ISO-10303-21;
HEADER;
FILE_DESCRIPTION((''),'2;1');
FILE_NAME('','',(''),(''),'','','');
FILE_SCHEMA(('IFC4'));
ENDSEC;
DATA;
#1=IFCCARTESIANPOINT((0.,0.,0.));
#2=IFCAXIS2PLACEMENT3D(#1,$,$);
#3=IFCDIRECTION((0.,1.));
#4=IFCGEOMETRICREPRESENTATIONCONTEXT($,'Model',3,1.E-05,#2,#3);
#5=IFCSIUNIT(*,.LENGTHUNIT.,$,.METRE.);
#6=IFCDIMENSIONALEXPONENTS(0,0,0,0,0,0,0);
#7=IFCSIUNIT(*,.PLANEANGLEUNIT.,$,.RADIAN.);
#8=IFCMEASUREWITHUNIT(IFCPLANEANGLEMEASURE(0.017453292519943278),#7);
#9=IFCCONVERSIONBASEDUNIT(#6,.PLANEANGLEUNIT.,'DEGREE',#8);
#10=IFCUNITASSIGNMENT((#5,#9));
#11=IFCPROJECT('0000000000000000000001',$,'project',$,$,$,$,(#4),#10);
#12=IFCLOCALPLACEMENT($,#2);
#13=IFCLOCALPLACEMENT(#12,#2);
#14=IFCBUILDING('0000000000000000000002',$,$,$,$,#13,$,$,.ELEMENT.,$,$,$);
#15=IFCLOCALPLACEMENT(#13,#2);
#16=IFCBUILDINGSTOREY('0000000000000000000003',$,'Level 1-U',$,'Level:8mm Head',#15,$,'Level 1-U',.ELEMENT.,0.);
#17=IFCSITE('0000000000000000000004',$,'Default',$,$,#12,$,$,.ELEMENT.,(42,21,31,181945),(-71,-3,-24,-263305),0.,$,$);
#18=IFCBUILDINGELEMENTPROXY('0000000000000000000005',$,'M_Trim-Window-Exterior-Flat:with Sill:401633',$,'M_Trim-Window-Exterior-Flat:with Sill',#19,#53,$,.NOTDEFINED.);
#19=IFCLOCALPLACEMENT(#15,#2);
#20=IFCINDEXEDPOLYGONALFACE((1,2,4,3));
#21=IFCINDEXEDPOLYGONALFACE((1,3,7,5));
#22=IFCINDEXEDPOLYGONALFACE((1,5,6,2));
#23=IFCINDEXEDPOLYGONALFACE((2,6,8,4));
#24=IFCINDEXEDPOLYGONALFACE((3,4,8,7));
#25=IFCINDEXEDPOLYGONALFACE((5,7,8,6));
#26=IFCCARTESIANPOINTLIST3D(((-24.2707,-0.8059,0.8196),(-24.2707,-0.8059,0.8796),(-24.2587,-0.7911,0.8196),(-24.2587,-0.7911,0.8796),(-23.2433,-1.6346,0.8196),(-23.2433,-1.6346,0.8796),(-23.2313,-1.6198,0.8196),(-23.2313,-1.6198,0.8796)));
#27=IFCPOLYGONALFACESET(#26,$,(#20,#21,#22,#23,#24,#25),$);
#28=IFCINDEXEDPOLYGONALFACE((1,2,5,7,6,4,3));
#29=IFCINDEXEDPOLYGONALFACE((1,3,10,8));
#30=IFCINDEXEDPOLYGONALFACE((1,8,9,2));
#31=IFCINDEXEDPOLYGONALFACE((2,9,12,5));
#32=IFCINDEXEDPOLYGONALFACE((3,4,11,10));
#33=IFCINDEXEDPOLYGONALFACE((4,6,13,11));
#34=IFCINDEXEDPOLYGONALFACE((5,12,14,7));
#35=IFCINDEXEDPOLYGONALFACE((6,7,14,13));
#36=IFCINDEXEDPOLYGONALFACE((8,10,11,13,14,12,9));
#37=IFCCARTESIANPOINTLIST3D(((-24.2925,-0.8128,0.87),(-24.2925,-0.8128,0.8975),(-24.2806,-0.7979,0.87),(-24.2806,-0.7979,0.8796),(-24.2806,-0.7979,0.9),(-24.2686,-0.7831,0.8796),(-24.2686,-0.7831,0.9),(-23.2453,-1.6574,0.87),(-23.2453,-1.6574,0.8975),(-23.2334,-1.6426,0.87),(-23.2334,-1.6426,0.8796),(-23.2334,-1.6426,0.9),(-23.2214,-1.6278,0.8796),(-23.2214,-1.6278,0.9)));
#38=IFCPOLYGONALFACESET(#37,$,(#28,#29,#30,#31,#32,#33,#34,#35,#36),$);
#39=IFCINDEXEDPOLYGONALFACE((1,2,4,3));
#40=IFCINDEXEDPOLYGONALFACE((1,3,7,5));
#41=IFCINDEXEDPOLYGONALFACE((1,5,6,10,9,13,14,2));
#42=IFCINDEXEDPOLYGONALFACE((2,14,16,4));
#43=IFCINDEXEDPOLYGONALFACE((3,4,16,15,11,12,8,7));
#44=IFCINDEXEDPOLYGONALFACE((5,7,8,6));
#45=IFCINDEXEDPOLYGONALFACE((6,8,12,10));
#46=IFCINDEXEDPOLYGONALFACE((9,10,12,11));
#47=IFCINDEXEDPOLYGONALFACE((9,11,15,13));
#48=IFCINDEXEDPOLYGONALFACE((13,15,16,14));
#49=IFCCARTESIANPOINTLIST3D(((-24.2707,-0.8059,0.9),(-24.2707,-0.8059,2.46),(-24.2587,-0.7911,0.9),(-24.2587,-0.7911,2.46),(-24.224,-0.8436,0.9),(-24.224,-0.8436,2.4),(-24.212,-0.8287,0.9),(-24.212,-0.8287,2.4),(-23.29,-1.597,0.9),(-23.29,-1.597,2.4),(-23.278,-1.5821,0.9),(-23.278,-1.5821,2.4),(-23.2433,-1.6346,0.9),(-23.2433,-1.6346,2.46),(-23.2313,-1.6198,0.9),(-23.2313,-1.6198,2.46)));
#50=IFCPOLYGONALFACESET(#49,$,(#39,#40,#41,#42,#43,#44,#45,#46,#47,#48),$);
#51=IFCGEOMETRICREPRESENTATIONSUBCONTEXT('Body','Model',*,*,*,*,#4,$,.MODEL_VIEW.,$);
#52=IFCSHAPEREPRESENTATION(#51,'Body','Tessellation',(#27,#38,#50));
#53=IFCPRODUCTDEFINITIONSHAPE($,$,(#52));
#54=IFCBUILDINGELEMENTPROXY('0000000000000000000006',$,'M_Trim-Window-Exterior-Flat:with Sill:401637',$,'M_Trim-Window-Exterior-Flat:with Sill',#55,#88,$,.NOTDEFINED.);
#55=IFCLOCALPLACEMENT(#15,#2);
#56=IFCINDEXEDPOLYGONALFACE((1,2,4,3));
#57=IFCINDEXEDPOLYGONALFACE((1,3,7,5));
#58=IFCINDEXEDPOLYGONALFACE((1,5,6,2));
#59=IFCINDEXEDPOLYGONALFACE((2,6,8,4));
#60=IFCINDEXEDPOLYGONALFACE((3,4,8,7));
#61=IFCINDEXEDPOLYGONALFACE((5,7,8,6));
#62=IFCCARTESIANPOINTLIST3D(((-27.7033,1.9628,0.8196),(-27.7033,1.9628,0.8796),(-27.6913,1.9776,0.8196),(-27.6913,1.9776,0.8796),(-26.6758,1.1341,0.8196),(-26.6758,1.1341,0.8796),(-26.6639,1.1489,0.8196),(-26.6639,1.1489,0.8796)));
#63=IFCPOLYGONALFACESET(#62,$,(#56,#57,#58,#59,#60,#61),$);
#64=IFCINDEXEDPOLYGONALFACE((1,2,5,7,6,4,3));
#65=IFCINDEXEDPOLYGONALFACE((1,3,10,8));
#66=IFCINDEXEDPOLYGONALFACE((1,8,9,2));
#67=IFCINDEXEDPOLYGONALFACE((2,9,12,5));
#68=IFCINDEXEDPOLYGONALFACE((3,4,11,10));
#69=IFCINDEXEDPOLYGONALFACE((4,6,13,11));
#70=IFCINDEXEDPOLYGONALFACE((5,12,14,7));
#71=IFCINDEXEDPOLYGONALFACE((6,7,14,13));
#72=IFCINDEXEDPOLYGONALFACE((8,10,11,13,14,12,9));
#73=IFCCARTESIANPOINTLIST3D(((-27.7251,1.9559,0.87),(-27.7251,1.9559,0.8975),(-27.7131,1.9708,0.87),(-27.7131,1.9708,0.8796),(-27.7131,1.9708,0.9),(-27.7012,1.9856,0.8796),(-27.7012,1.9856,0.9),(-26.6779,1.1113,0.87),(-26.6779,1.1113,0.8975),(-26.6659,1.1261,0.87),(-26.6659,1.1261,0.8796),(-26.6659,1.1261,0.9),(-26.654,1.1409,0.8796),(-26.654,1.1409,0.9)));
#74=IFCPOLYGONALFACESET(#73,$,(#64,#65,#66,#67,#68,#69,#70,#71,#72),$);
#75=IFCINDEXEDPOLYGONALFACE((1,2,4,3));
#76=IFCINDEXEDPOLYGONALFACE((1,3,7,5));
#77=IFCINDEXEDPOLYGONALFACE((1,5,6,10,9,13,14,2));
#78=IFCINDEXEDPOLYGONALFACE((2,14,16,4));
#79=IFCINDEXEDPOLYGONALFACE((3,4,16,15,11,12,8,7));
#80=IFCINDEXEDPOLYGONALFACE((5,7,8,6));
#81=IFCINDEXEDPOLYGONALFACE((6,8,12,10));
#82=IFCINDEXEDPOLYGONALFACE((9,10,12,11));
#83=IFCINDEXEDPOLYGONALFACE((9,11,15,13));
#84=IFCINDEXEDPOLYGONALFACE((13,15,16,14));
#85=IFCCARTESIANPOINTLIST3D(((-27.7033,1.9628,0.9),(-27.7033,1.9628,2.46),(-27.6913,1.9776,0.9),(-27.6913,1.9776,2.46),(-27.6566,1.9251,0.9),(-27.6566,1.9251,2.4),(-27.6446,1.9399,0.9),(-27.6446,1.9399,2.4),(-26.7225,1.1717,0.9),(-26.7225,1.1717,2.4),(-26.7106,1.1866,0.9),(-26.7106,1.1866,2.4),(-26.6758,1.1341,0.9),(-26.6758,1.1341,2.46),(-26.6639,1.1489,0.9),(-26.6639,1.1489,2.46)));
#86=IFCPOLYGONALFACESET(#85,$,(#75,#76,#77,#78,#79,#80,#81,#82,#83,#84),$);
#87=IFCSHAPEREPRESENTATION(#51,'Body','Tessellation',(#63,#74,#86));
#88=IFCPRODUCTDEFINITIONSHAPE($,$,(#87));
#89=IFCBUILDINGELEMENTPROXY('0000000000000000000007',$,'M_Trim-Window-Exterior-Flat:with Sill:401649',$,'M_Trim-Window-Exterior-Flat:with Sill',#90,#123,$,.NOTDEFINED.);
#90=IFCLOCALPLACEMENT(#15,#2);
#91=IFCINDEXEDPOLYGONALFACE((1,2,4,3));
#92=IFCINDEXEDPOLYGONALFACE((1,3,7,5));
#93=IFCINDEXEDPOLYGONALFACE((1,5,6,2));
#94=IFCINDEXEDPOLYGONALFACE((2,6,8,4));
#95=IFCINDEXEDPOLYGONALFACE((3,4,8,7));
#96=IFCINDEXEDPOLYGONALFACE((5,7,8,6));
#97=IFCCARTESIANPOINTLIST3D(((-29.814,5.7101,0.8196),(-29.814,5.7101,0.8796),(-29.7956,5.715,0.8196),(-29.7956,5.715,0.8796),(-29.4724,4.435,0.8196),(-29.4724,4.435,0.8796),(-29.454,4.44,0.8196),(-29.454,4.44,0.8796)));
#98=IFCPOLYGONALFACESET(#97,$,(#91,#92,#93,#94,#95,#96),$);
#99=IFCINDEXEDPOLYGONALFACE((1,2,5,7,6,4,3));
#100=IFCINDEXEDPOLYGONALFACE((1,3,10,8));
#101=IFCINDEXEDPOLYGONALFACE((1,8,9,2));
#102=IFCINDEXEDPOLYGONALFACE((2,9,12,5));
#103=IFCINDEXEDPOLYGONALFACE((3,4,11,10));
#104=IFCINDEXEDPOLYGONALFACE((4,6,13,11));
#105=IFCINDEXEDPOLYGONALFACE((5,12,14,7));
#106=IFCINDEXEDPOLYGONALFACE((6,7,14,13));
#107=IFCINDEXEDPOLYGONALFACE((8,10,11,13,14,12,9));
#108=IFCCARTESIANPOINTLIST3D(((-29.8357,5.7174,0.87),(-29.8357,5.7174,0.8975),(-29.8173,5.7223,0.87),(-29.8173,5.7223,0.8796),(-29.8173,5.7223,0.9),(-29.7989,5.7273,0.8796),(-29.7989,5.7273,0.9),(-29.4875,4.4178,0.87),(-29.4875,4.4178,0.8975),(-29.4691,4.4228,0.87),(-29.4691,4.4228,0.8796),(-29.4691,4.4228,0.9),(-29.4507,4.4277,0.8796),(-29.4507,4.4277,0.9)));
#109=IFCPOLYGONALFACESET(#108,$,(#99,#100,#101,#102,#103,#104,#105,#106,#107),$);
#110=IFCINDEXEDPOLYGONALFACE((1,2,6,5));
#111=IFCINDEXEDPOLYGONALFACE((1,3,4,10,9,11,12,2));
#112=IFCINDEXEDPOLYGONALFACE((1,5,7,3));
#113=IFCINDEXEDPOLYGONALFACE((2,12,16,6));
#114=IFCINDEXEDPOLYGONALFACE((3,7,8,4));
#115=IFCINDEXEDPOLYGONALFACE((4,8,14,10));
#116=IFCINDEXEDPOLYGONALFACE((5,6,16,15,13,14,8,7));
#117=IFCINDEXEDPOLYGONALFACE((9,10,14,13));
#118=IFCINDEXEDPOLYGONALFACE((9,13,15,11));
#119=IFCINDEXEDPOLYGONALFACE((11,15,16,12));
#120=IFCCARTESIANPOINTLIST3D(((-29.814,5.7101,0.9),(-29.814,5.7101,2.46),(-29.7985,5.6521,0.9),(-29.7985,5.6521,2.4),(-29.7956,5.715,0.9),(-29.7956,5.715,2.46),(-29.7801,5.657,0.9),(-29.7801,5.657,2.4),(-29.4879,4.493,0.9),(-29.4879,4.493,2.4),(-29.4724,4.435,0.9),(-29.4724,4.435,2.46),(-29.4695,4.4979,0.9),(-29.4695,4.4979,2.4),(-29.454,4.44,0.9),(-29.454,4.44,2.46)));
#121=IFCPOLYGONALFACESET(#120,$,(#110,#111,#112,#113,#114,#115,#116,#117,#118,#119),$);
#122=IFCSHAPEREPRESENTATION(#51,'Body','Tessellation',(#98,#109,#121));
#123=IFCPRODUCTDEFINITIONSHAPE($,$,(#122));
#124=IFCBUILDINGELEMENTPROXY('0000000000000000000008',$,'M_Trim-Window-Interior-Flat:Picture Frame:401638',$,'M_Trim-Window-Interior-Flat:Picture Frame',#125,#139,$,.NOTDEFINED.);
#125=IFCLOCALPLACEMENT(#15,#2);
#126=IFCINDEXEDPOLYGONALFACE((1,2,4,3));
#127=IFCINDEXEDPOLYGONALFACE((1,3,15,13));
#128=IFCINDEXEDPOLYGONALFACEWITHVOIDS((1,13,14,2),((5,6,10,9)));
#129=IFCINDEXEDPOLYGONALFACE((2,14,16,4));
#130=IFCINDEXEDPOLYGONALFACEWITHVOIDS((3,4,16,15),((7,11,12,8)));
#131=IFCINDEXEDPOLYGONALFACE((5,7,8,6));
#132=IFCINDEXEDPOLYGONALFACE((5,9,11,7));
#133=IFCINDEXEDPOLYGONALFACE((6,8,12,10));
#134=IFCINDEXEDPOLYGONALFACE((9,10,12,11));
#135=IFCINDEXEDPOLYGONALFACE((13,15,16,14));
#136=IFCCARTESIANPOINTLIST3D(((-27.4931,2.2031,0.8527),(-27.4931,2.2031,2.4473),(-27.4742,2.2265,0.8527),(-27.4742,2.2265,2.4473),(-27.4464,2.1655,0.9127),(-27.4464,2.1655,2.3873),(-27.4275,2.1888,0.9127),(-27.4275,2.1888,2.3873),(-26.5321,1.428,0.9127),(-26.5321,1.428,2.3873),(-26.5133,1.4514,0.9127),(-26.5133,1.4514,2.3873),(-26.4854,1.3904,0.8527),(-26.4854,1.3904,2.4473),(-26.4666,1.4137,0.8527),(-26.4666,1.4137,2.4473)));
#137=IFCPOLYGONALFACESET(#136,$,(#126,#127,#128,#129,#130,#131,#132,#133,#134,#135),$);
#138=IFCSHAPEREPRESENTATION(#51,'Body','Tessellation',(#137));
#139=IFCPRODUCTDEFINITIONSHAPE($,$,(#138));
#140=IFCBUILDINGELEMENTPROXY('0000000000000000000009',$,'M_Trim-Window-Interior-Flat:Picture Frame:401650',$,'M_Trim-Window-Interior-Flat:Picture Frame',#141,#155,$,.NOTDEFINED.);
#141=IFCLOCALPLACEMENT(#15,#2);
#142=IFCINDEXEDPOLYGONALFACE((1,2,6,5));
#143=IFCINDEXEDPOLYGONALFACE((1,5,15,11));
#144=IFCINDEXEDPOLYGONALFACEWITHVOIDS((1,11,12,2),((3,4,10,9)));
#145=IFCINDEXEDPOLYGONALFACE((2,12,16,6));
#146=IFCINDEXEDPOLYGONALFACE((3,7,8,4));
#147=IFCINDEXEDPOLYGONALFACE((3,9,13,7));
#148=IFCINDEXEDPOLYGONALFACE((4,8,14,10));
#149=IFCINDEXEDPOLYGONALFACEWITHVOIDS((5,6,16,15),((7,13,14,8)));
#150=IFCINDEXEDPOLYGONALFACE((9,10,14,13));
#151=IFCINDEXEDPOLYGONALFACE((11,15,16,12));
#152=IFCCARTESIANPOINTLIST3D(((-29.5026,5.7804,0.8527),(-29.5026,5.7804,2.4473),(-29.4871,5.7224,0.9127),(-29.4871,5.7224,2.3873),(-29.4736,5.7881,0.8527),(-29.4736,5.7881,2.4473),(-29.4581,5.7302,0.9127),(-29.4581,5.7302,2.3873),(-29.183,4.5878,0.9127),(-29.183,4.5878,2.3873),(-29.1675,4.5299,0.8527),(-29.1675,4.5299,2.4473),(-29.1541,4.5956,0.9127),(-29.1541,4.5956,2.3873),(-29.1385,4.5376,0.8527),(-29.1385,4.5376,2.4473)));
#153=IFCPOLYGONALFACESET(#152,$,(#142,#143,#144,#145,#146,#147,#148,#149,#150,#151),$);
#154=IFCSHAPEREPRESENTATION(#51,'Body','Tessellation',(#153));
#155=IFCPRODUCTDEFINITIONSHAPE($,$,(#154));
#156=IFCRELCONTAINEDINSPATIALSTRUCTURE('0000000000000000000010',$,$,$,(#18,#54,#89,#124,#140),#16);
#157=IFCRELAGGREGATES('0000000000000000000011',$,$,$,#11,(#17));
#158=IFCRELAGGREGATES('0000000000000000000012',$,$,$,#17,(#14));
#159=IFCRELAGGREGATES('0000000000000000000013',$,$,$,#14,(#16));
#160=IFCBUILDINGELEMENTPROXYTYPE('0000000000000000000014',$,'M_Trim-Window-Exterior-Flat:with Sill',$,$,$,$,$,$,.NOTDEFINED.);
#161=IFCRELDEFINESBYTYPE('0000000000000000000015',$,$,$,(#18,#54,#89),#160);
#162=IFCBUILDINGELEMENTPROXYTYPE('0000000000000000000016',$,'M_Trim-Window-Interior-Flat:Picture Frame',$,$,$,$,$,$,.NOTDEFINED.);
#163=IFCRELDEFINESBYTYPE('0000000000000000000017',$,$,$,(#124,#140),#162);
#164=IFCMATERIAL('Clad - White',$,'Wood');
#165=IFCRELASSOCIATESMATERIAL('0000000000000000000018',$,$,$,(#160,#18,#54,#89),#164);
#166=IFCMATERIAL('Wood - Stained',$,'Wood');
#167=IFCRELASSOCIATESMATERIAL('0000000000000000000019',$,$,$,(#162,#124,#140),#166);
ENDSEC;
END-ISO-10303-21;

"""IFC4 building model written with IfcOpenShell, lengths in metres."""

from ifc_helpers import new_model, entity, si_unit, converted_unit, direction, frame, frame_2d, origin, place, context, subcontext, project, spatial, polyline, rectangle, outline, extrude, source, transform, mapped, material, type_object, type_shapes, element, save


model = new_model("IFC4")

# Units and contexts
model_context = context("Model", 3, precision=1e-05, world=origin(), true_north=direction((0.0, 1.0)))
body_context = subcontext(model_context, "Body", "Model", "MODEL_VIEW")
ifc_project = project(units=[si_unit("LENGTHUNIT", "METRE"), converted_unit("PLANEANGLEUNIT", "DEGREE", entity("IfcPlaneAngleMeasure", 0.017453292519943278), si_unit("PLANEANGLEUNIT", "RADIAN"), dimensions=[0, 0, 0, 0, 0, 0, 0])], contexts=[model_context])

# Site, building, storey
site_placement = place(None, origin())
site = spatial("IfcSite", under=ifc_project, at=site_placement, Name="Default", CompositionType="ELEMENT", RefLatitude=(42, 21, 31, 181945), RefLongitude=(-71, -3, -24, -263305), RefElevation=0.0)
building_placement = place(site_placement, origin())
building = spatial("IfcBuilding", under=site, at=building_placement, CompositionType="ELEMENT")
storey_placement = place(building_placement, origin())
storey = spatial("IfcBuildingStorey", under=building, at=storey_placement, Name="Level 1-U", ObjectType="Level:8mm Head", LongName="Level 1-U", CompositionType="ELEMENT", Elevation=0.0)

# Building element proxies
ifc_material_1 = material(Name="Clad - White", Category="Wood")
ifc_material_2 = material(Name="Wood - Stained", Category="Wood")
building_element_proxy_type_1 = type_object("IfcBuildingElementProxyType", Name="M_Trim-Window-Exterior-Flat:with Sill", PredefinedType="NOTDEFINED", material=ifc_material_1)
shared_shape_1 = source(origin(), body_context, "Body", "SweptSolid", [
    extrude(rectangle(XDim=1.32, YDim=0.06, at=frame_2d((0.0, 0.0), x_axis=(1.0, 0.0))), frame((0.0, -1.5504, 0.0), z_axis=(0.0, 0.0, 1.0), x_axis=(-1.0, 0.0, 0.0)), (0.0, 0.0, 1.0), 0.019),
    extrude(outline(polyline([(-0.019, -0.0152), (0.0, -0.0152), (0.0, -0.0057), (0.019, -0.0057), (0.019, 0.0148), (0.0, 0.0148), (-0.019, 0.0123), (-0.019, -0.0152)])), frame((-0.6727, -1.5148, 0.019), z_axis=(1.0, 0.0, 0.0), x_axis=(0.0, 0.0, -1.0)), (0.0, 0.0, 1.0), 1.3454),
    extrude(outline(polyline([(-0.795, -0.66), (0.765, -0.66), (0.765, -0.6), (-0.735, -0.6), (-0.735, 0.6), (0.765, 0.6), (0.765, 0.66), (-0.795, 0.66), (-0.795, -0.66)])), frame((0.0, -0.735, 0.0), z_axis=(0.0, 0.0, 1.0), x_axis=(0.0, -1.0, 0.0)), (0.0, 0.0, 1.0), 0.019),
])
type_shapes(building_element_proxy_type_1, [shared_shape_1])
for number, where, z_axis, x_axis, name in (
    (1, (-23.745, -1.2054, 2.4), (-0.62782, -0.778359, 0.0), (0.778359, -0.62782, 0.0), "M_Trim-Window-Exterior-Flat:with Sill:401633"),
    (2, (-27.1776, 1.5632, 2.4), (-0.62782, -0.778359, 0.0), (0.778359, -0.62782, 0.0), "M_Trim-Window-Exterior-Flat:with Sill:401637"),
    (3, (-29.6248, 5.0775, 2.4), (-0.965926, -0.258819, 0.0), (0.258819, -0.965926, 0.0), "M_Trim-Window-Exterior-Flat:with Sill:401649"),
):
    element("IfcBuildingElementProxy", number, at=place(storey_placement, frame(where, z_axis=z_axis, x_axis=x_axis)), inside=storey, type_object=building_element_proxy_type_1, material=ifc_material_1, Name=name, ObjectType="M_Trim-Window-Exterior-Flat:with Sill", PredefinedType="NOTDEFINED", context=body_context, shape_type="MappedRepresentation", body=[
        mapped(shared_shape_1, transform((0.0, 0.0, 0.0), scale=1.0)),
    ])
building_element_proxy_type_2 = type_object("IfcBuildingElementProxyType", Name="M_Trim-Window-Interior-Flat:Picture Frame", PredefinedType="NOTDEFINED", material=ifc_material_2)
shared_shape_2 = source(origin(), body_context, "Body", "SweptSolid", [
    extrude(outline(polyline([(-0.6473, -0.7973), (0.6473, -0.7973), (0.6473, 0.7973), (-0.6473, 0.7973), (-0.6473, -0.7973)]), holes=[polyline([(-0.5873, -0.7373), (-0.5873, 0.7373), (0.5873, 0.7373), (0.5873, -0.7373), (-0.5873, -0.7373)])]), frame((0.0, -0.75, 0.0), z_axis=(0.0, 0.0, 1.0), x_axis=(-1.0, 0.0, 0.0)), (0.0, 0.0, 1.0), 0.03),
])
type_shapes(building_element_proxy_type_2, [shared_shape_2])
for number, where, z_axis, x_axis, name in (
    (4, (-26.9892, 1.7968, 2.4), (0.62782, 0.778359, 0.0), (-0.778359, 0.62782, 0.0), "M_Trim-Window-Interior-Flat:Picture Frame:401638"),
    (5, (-29.335, 5.1551, 2.4), (0.965926, 0.258819, 0.0), (-0.258819, 0.965926, 0.0), "M_Trim-Window-Interior-Flat:Picture Frame:401650"),
):
    element("IfcBuildingElementProxy", number, at=place(storey_placement, frame(where, z_axis=z_axis, x_axis=x_axis)), inside=storey, type_object=building_element_proxy_type_2, material=ifc_material_2, Name=name, ObjectType="M_Trim-Window-Interior-Flat:Picture Frame", PredefinedType="NOTDEFINED", context=body_context, shape_type="MappedRepresentation", body=[
        mapped(shared_shape_2, transform((0.0, 0.0, 0.0), scale=1.0)),
    ])

save(model, "model.ifc")
